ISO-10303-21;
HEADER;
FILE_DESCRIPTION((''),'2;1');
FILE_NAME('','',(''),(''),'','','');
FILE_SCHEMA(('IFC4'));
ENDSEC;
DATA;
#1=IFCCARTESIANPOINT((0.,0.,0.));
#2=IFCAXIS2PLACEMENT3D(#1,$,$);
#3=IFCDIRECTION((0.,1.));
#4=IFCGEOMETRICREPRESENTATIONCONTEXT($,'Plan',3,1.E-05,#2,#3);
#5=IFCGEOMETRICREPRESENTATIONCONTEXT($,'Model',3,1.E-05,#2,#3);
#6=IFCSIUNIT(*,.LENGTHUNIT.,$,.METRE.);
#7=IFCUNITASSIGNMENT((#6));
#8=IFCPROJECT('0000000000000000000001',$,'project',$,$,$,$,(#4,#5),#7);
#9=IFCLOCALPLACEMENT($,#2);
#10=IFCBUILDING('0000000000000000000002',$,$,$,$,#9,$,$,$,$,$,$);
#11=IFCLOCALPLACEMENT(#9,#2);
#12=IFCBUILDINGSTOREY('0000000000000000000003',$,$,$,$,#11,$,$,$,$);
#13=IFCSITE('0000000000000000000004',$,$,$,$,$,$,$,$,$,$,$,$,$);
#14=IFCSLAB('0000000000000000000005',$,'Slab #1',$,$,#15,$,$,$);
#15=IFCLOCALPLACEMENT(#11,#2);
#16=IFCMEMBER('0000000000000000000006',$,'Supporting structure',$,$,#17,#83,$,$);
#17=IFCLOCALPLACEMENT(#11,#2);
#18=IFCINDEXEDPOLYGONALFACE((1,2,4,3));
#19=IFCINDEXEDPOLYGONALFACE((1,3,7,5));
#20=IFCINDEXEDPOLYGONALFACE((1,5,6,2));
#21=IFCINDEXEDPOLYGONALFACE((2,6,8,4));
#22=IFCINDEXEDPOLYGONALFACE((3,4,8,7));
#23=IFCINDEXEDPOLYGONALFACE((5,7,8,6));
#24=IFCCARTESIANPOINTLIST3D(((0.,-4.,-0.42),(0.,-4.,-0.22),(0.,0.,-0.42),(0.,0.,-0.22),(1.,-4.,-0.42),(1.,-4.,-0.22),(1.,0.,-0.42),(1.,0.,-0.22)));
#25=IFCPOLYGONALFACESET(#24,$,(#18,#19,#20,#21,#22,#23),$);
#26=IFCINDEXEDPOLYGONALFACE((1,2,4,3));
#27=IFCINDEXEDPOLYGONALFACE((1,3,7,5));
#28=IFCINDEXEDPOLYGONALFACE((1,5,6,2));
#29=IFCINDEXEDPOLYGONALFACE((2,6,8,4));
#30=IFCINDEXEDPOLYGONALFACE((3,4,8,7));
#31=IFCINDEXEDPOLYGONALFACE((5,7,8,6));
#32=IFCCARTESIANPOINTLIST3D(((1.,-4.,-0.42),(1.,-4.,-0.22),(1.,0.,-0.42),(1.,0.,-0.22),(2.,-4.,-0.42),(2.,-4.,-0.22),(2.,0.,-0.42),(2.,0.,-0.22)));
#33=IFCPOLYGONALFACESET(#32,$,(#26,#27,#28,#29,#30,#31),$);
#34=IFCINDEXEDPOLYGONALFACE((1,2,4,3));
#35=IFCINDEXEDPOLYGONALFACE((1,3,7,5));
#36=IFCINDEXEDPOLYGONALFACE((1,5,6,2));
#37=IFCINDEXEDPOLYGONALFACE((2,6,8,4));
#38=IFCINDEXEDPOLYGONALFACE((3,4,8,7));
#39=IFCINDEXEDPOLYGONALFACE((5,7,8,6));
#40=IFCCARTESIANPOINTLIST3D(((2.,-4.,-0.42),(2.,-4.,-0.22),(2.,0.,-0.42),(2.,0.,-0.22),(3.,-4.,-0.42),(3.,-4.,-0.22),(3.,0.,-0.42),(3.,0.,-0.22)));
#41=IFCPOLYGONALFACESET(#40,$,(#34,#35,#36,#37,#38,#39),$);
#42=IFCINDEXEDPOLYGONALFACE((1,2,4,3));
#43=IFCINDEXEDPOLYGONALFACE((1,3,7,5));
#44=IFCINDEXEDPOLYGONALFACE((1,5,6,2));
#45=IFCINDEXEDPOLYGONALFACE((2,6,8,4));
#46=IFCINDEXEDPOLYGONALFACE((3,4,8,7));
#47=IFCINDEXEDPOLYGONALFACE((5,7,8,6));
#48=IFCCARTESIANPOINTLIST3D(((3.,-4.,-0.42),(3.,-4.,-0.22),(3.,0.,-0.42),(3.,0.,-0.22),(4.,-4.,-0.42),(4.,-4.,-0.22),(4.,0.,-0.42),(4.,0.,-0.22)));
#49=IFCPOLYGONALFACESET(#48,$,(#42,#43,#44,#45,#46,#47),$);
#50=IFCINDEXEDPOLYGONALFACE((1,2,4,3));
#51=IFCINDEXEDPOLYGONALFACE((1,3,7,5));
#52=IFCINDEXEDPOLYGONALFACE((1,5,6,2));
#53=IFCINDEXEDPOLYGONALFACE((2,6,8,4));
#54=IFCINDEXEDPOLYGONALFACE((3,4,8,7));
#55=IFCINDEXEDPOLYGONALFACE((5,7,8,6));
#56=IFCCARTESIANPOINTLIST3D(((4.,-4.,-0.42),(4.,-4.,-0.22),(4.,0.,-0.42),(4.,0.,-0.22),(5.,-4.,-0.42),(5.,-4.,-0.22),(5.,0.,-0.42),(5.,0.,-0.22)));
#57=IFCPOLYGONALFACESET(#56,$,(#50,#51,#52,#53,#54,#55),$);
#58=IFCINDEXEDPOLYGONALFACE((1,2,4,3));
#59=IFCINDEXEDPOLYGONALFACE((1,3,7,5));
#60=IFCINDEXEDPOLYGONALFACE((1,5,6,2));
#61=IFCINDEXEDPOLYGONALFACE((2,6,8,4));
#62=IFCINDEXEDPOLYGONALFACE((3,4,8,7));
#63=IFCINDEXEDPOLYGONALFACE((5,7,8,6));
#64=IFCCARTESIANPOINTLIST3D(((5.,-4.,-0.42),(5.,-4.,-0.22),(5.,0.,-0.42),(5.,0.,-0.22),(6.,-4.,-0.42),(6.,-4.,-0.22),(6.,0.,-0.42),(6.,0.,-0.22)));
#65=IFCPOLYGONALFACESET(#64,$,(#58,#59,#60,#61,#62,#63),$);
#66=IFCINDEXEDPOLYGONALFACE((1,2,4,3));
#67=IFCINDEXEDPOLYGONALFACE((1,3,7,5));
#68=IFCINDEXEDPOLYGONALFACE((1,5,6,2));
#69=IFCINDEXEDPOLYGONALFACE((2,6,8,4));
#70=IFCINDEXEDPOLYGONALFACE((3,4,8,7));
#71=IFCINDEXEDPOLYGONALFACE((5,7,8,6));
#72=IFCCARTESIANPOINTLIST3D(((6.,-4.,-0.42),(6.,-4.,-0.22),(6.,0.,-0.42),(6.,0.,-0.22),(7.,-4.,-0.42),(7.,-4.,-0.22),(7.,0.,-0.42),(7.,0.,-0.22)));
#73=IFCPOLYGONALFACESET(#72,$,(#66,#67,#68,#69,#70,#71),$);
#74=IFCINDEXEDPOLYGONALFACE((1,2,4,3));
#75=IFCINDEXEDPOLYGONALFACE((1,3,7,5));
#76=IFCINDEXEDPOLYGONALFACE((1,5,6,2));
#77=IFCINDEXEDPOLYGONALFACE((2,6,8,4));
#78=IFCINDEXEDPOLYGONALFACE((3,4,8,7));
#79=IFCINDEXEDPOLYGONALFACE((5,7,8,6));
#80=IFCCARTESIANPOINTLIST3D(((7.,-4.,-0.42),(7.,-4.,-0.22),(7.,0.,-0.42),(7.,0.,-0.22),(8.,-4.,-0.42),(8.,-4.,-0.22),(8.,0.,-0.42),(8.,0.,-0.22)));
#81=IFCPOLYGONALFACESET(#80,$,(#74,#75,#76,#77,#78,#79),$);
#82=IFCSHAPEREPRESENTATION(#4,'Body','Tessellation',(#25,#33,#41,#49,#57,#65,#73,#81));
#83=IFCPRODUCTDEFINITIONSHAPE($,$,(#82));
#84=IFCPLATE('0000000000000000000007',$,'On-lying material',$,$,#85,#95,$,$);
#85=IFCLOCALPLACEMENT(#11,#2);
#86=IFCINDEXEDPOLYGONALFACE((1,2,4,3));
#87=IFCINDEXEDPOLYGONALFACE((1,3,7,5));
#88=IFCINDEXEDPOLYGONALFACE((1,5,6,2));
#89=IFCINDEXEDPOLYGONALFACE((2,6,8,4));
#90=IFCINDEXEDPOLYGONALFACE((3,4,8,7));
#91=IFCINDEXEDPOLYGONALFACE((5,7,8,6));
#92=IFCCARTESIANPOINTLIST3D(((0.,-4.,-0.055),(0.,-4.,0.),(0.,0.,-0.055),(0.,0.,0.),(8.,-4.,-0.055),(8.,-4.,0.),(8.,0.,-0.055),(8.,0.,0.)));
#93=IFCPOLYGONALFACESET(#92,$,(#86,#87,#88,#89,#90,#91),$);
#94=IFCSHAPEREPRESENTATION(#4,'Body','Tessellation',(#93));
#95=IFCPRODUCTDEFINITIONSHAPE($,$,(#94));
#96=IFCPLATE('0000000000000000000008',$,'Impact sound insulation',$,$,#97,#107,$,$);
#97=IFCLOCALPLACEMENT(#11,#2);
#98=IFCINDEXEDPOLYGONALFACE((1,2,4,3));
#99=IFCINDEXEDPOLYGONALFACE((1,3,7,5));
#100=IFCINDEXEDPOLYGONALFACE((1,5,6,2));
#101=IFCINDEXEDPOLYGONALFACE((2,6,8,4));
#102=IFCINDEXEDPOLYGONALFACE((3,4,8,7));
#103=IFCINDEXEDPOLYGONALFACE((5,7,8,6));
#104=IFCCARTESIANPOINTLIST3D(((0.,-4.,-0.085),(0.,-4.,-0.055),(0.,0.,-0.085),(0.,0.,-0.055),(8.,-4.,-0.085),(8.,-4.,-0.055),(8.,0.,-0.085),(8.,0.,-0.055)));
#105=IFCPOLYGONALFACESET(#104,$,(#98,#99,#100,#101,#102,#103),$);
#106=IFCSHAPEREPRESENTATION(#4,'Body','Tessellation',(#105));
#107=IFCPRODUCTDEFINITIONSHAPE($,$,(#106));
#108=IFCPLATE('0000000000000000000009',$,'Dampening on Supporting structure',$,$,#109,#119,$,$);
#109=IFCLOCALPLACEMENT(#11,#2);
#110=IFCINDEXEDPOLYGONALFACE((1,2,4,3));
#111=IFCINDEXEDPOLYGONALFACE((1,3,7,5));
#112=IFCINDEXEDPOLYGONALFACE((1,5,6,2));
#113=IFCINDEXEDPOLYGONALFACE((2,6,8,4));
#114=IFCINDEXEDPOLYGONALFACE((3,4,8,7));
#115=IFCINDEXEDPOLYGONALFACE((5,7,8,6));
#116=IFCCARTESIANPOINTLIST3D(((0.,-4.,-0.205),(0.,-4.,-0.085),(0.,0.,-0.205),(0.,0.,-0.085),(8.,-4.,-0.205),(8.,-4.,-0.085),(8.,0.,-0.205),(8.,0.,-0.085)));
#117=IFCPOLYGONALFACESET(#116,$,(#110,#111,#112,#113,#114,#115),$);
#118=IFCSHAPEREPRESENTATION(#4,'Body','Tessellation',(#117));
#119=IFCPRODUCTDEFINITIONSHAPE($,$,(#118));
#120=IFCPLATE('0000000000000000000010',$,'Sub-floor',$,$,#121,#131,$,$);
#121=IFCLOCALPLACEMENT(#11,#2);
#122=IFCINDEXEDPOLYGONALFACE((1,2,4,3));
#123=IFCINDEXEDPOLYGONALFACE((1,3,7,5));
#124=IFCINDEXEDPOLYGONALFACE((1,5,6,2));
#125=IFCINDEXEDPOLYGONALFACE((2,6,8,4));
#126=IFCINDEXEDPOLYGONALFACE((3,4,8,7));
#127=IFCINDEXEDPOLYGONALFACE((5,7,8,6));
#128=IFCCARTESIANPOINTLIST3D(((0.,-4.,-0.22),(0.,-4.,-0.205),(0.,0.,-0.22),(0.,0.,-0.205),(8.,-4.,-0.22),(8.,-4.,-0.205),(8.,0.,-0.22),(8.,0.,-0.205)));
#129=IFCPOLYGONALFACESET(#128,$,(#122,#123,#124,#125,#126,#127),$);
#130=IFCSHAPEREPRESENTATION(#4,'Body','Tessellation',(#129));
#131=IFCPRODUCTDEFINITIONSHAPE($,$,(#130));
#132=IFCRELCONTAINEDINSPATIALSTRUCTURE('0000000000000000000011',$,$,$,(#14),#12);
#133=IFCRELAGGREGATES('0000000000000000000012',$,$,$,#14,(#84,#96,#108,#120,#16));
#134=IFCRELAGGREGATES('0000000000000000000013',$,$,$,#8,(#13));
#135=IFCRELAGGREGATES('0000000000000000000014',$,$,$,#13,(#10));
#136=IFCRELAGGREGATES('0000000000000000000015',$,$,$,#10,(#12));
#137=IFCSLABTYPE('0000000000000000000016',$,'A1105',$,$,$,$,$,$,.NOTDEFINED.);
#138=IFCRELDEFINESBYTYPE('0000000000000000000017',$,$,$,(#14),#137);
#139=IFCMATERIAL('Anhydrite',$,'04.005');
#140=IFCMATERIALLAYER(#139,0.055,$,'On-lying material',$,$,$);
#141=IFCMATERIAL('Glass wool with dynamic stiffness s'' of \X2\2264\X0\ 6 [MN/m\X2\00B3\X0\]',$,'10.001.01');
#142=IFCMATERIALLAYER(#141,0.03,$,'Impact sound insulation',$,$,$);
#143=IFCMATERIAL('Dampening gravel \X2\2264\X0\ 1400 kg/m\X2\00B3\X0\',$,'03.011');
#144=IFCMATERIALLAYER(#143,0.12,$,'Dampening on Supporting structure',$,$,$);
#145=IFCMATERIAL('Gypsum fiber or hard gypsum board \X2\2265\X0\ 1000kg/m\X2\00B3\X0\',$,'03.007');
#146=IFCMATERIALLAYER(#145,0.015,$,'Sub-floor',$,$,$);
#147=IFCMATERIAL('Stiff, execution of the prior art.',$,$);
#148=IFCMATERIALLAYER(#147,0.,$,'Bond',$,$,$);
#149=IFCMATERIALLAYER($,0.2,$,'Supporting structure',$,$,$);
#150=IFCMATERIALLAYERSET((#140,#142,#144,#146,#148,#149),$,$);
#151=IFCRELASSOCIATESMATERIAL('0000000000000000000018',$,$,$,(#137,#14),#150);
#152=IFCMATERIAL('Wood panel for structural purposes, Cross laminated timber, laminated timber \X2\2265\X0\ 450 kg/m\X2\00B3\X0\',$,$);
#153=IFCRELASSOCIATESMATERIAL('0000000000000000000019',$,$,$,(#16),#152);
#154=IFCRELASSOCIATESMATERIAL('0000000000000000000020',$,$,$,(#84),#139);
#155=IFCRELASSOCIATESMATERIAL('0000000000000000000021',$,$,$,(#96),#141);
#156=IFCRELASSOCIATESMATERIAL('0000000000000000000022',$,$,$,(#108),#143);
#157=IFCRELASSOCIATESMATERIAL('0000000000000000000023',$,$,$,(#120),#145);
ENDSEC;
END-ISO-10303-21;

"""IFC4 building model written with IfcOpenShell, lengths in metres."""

from ifc_helpers import new_model, si_unit, direction, frame, frame_2d, origin, origin_with_axes, place, context, project, spatial, rectangle, extrude, material, layer, layer_set, type_object, element, aggregate, save


model = new_model("IFC4")

# Units and contexts
plan_context = context("Plan", 3, precision=1e-05, world=origin(), true_north=direction((0.0, 1.0)))
model_context = context("Model", 3, precision=1e-05, world=origin(), true_north=direction((0.0, 1.0)))
ifc_project = project(units=[si_unit("LENGTHUNIT", "METRE")], contexts=[plan_context, model_context])

# Site, building, storey
site = spatial("IfcSite", under=ifc_project)
building_placement = place(None, origin())
building = spatial("IfcBuilding", under=site, at=building_placement)
storey_placement = place(building_placement, origin())
storey = spatial("IfcBuildingStorey", under=building, at=storey_placement)

# Slab, member, plates
ifc_material_1 = material(Name="Anhydrite", Category="04.005")
ifc_layer_1 = layer(ifc_material_1, 0.055, Name="On-lying material")
ifc_material_2 = material(Name="Glass wool with dynamic stiffness s' of ≤ 6 [MN/m³]", Category="10.001.01")
ifc_layer_2 = layer(ifc_material_2, 0.03, Name="Impact sound insulation")
ifc_material_3 = material(Name="Dampening gravel ≤ 1400 kg/m³", Category="03.011")
ifc_layer_3 = layer(ifc_material_3, 0.12, Name="Dampening on Supporting structure")
ifc_material_4 = material(Name="Gypsum fiber or hard gypsum board ≥ 1000kg/m³", Category="03.007")
ifc_layer_4 = layer(ifc_material_4, 0.015, Name="Sub-floor")
ifc_material_5 = material(Name="Stiff, execution of the prior art.")
ifc_layer_5 = layer(ifc_material_5, 0.0, Name="Bond")
ifc_layer_6 = layer(None, 0.2, Name="Supporting structure")
ifc_layer_set = layer_set([ifc_layer_1, ifc_layer_2, ifc_layer_3, ifc_layer_4, ifc_layer_5, ifc_layer_6])
slab_type = type_object("IfcSlabType", Name="A1105", PredefinedType="NOTDEFINED", material=ifc_layer_set)
slab_placement = place(None, frame((0.0, 0.0, 0.0), z_axis=(0.0, 0.0, -1.0), x_axis=(1.0, 0.0, 0.0)))
slab = element("IfcSlab", 1, at=slab_placement, inside=storey, type_object=slab_type, material=ifc_layer_set, Name="Slab #1")
ifc_material_6 = material(Name="Wood panel for structural purposes, Cross laminated timber, laminated timber ≥ 450 kg/m³")
member_placement = place(slab_placement, origin())
member = element("IfcMember", 2, at=member_placement, material=ifc_material_6, Name="Supporting structure", context=plan_context, shape_type="SweptSolid", body=[
    extrude(rectangle(XDim=1.0, YDim=0.2, at=frame_2d((0.5, 0.1), x_axis=(1.0, 0.0))), frame((0.0, 4.0, 0.22), z_axis=(0.0, -1.0, 0.0), x_axis=(1.0, 0.0, 0.0)), (0.0, 0.0, 1.0), 4.0),
    extrude(rectangle(XDim=1.0, YDim=0.2, at=frame_2d((0.5, 0.1), x_axis=(1.0, 0.0))), frame((1.0, 4.0, 0.22), z_axis=(0.0, -1.0, 0.0), x_axis=(1.0, 0.0, 0.0)), (0.0, 0.0, 1.0), 4.0),
    extrude(rectangle(XDim=1.0, YDim=0.2, at=frame_2d((0.5, 0.1), x_axis=(1.0, 0.0))), frame((2.0, 4.0, 0.22), z_axis=(0.0, -1.0, 0.0), x_axis=(1.0, 0.0, 0.0)), (0.0, 0.0, 1.0), 4.0),
    extrude(rectangle(XDim=1.0, YDim=0.2, at=frame_2d((0.5, 0.1), x_axis=(1.0, 0.0))), frame((3.0, 4.0, 0.22), z_axis=(0.0, -1.0, 0.0), x_axis=(1.0, 0.0, 0.0)), (0.0, 0.0, 1.0), 4.0),
    extrude(rectangle(XDim=1.0, YDim=0.2, at=frame_2d((0.5, 0.1), x_axis=(1.0, 0.0))), frame((4.0, 4.0, 0.22), z_axis=(0.0, -1.0, 0.0), x_axis=(1.0, 0.0, 0.0)), (0.0, 0.0, 1.0), 4.0),
    extrude(rectangle(XDim=1.0, YDim=0.2, at=frame_2d((0.5, 0.1), x_axis=(1.0, 0.0))), frame((5.0, 4.0, 0.22), z_axis=(0.0, -1.0, 0.0), x_axis=(1.0, 0.0, 0.0)), (0.0, 0.0, 1.0), 4.0),
    extrude(rectangle(XDim=1.0, YDim=0.2, at=frame_2d((0.5, 0.1), x_axis=(1.0, 0.0))), frame((6.0, 4.0, 0.22), z_axis=(0.0, -1.0, 0.0), x_axis=(1.0, 0.0, 0.0)), (0.0, 0.0, 1.0), 4.0),
    extrude(rectangle(XDim=1.0, YDim=0.2, at=frame_2d((0.5, 0.1), x_axis=(1.0, 0.0))), frame((7.0, 4.0, 0.22), z_axis=(0.0, -1.0, 0.0), x_axis=(1.0, 0.0, 0.0)), (0.0, 0.0, 1.0), 4.0),
])
plate_1_placement = place(slab_placement, origin())
plate_1 = element("IfcPlate", 3, at=plate_1_placement, material=ifc_material_1, Name="On-lying material", context=plan_context, shape_type="SweptSolid", body=[
    extrude(rectangle(XDim=8.0, YDim=4.0, at=frame_2d((4.0, 2.0), x_axis=(1.0, 0.0))), origin_with_axes(), (0.0, 0.0, 1.0), 0.055),
])
plate_2_placement = place(slab_placement, origin())
plate_2 = element("IfcPlate", 4, at=plate_2_placement, material=ifc_material_2, Name="Impact sound insulation", context=plan_context, shape_type="SweptSolid", body=[
    extrude(rectangle(XDim=8.0, YDim=4.0, at=frame_2d((4.0, 2.0), x_axis=(1.0, 0.0))), frame((0.0, 0.0, 0.055), z_axis=(0.0, 0.0, 1.0), x_axis=(1.0, 0.0, 0.0)), (0.0, 0.0, 1.0), 0.03),
])
plate_3_placement = place(slab_placement, origin())
plate_3 = element("IfcPlate", 5, at=plate_3_placement, material=ifc_material_3, Name="Dampening on Supporting structure", context=plan_context, shape_type="SweptSolid", body=[
    extrude(rectangle(XDim=8.0, YDim=4.0, at=frame_2d((4.0, 2.0), x_axis=(1.0, 0.0))), frame((0.0, 0.0, 0.085), z_axis=(0.0, 0.0, 1.0), x_axis=(1.0, 0.0, 0.0)), (0.0, 0.0, 1.0), 0.12),
])
plate_4_placement = place(slab_placement, origin())
plate_4 = element("IfcPlate", 6, at=plate_4_placement, material=ifc_material_4, Name="Sub-floor", context=plan_context, shape_type="SweptSolid", body=[
    extrude(rectangle(XDim=8.0, YDim=4.0, at=frame_2d((4.0, 2.0), x_axis=(1.0, 0.0))), frame((0.0, 0.0, 0.205), z_axis=(0.0, 0.0, 1.0), x_axis=(1.0, 0.0, 0.0)), (0.0, 0.0, 1.0), 0.015),
])
aggregate(slab, [plate_1, plate_2, plate_3, plate_4, member])

save(model, "model.ifc")
